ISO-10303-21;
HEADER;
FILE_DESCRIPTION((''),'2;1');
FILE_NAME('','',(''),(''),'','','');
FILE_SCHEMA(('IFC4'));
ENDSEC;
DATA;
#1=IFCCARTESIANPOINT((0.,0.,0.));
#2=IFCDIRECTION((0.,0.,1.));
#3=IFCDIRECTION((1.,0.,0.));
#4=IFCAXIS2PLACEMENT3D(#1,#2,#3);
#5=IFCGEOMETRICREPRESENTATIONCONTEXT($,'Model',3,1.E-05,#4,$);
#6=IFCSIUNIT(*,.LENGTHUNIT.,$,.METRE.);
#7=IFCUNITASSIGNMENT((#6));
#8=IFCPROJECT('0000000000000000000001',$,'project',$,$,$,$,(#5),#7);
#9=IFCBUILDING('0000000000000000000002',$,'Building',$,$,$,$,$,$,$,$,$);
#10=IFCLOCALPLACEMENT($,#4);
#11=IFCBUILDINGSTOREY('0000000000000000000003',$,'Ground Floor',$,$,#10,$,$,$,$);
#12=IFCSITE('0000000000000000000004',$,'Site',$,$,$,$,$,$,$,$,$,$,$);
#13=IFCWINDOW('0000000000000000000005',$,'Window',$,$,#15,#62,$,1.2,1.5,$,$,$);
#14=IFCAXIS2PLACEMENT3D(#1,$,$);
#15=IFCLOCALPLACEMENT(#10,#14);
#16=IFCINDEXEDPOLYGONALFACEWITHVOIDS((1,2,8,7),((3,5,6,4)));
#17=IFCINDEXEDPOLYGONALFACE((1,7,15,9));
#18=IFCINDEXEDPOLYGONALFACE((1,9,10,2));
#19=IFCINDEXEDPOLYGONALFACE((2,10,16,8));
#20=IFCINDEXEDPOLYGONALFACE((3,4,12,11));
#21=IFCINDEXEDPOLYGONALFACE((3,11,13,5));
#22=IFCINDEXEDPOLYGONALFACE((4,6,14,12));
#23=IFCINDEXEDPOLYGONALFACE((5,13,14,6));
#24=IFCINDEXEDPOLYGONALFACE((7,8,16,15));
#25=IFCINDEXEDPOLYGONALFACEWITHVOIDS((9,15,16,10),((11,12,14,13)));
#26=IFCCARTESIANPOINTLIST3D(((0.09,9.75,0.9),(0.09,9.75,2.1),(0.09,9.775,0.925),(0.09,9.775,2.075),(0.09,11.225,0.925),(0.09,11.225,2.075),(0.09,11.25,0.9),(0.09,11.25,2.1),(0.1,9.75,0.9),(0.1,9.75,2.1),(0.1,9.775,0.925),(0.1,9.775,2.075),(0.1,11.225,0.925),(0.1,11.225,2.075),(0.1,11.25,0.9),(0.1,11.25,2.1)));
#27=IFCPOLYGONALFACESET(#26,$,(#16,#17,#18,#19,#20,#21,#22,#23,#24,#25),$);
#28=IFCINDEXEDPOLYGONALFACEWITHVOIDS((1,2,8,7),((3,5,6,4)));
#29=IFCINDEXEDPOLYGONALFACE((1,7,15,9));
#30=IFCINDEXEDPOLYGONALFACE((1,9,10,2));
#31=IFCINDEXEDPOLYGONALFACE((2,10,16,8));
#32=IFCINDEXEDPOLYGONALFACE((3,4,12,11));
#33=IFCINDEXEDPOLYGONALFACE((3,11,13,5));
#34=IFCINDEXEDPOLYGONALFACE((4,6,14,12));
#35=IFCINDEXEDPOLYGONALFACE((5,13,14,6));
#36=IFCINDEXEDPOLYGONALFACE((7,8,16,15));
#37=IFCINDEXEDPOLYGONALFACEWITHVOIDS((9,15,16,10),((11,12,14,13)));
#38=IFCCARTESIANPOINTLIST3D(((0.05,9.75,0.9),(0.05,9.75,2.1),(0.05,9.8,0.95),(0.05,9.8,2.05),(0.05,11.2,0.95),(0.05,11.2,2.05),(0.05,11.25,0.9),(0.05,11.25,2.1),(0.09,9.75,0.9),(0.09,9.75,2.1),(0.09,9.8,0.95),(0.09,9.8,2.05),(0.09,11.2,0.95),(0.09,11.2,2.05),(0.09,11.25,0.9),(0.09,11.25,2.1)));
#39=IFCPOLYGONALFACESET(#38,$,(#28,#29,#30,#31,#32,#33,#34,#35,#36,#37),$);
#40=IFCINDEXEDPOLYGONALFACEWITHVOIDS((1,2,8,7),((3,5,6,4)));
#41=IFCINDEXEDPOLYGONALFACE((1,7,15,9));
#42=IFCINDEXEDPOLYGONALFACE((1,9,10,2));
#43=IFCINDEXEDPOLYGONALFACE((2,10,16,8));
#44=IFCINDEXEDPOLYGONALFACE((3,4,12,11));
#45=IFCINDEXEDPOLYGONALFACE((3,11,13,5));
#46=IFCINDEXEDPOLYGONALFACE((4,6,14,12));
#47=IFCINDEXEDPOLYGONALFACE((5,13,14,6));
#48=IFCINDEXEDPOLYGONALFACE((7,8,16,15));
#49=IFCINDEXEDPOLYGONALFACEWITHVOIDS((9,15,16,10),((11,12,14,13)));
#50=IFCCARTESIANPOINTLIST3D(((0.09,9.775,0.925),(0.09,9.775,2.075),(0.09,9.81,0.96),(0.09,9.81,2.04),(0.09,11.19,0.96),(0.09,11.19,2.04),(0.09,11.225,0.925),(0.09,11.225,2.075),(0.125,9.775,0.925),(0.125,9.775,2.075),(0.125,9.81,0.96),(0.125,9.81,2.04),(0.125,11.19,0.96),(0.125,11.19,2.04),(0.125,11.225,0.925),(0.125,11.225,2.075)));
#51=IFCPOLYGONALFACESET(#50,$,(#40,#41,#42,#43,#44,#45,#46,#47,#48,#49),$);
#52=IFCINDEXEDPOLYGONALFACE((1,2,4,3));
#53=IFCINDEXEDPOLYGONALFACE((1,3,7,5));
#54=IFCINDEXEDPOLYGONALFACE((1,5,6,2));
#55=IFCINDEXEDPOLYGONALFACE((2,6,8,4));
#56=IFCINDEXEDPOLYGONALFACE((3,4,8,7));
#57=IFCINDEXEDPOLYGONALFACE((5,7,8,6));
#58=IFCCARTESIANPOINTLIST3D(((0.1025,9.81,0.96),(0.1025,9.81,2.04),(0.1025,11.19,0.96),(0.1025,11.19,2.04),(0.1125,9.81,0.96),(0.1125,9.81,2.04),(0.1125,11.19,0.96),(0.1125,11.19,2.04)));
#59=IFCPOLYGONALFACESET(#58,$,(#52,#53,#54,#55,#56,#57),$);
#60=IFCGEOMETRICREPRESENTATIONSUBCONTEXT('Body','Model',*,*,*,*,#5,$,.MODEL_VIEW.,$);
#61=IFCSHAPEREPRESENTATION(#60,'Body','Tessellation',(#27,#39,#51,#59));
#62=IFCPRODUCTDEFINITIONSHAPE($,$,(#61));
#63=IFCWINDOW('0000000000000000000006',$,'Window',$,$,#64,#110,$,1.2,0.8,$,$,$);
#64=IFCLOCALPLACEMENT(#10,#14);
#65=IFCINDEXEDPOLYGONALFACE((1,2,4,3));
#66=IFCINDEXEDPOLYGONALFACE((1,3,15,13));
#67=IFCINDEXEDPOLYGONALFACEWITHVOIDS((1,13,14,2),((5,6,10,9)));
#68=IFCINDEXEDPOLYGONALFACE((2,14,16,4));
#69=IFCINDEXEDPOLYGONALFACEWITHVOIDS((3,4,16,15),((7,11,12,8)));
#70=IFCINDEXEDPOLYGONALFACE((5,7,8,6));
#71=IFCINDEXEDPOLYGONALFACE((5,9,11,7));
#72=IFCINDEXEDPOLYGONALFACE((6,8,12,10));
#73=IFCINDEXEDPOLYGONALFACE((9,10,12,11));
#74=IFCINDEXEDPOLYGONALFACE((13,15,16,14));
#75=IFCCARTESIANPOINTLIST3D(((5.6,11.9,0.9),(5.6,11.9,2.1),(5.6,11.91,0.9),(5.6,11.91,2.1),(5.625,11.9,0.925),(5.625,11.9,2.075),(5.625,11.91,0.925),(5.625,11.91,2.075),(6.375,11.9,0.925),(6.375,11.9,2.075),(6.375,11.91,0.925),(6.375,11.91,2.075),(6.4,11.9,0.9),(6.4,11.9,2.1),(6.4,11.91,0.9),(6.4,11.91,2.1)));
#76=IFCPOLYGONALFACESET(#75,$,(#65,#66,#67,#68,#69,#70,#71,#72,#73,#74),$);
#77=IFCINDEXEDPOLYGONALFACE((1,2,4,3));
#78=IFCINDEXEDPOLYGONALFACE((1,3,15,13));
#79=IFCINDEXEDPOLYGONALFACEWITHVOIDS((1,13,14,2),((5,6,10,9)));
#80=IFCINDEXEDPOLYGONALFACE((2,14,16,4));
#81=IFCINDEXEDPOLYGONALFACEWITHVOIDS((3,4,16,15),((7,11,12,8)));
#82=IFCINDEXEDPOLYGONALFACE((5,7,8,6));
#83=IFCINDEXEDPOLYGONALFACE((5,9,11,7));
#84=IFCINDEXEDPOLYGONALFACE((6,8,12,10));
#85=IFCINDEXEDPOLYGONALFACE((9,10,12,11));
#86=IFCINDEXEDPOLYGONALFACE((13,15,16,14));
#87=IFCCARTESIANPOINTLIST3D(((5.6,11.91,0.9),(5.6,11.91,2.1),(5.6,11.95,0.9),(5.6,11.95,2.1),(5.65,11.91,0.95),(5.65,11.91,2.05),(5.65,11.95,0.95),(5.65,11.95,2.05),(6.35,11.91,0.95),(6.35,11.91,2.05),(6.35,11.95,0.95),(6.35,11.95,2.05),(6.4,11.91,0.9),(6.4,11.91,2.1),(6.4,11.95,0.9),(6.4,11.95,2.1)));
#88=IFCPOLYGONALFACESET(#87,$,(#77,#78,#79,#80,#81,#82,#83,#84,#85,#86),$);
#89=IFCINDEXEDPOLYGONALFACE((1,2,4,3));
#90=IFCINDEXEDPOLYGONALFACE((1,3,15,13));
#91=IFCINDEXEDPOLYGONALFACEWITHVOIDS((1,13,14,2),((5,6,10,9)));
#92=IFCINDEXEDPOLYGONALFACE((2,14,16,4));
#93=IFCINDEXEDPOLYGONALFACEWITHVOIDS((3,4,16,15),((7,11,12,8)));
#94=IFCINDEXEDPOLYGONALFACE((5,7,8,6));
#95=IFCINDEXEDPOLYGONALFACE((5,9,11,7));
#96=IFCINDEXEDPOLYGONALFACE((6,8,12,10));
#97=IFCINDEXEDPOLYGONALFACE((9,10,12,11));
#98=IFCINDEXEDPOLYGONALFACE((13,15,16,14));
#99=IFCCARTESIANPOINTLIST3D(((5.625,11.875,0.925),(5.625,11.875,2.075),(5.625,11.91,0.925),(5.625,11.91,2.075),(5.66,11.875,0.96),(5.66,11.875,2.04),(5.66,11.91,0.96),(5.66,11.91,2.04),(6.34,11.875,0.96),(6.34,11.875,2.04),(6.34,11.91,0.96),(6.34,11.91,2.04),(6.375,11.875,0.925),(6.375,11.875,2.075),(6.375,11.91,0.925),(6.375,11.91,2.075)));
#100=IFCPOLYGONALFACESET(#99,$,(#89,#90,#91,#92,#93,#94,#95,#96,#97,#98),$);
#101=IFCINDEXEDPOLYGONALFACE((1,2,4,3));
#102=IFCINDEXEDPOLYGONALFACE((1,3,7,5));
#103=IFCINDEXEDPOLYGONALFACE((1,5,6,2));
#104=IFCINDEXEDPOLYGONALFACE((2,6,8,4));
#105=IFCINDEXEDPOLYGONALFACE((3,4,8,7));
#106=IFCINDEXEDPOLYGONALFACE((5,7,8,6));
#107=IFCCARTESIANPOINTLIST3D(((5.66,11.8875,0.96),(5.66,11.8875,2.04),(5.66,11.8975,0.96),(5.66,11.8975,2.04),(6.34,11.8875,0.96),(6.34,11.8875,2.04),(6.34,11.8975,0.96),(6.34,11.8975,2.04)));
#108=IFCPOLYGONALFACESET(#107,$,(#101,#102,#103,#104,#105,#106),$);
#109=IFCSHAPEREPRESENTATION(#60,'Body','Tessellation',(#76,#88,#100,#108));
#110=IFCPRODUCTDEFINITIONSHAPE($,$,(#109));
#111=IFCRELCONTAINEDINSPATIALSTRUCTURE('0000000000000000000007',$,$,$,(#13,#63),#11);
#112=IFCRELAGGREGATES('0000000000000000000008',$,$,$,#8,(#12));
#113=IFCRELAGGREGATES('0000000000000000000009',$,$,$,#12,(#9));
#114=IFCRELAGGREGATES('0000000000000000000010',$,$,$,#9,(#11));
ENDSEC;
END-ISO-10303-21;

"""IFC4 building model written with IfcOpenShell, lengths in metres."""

from ifc_helpers import new_model, si_unit, frame, origin_with_axes, place, context, subcontext, project, spatial, line, indexed_curve, outline, extrude, element, save


model = new_model("IFC4")

# Units and contexts
model_context = context("Model", 3, precision=1e-05, world=origin_with_axes())
body_context = subcontext(model_context, "Body", "Model", "MODEL_VIEW")
ifc_project = project(units=[si_unit("LENGTHUNIT", "METRE")], contexts=[model_context])

# Site, building, storey
site = spatial("IfcSite", under=ifc_project, Name="Site")
building = spatial("IfcBuilding", under=site, Name="Building")
storey_placement = place(None, origin_with_axes())
storey = spatial("IfcBuildingStorey", under=building, at=storey_placement, Name="Ground Floor")

# Windows
window_1_placement = place(storey_placement, frame((0.0, 11.25, 0.9), z_axis=(0.0, 0.0, 1.0), x_axis=(0.0, -1.0, 0.0)))
element("IfcWindow", 1, at=window_1_placement, inside=storey, Name="Window", OverallHeight=1.2, OverallWidth=1.5, context=body_context, shape_type="SweptSolid", body=[
    extrude(outline(indexed_curve([(0.0, 0.0), (1.5, 0.0), (1.5, 1.2), (0.0, 1.2)], segments=[line(1, 2, 3, 4, 1)]), holes=[indexed_curve([(0.025, 0.025), (1.475, 0.025), (1.475, 1.175), (0.025, 1.175)], segments=[line(1, 2, 3, 4, 1)])]), frame((0.0, 0.09, 0.0), z_axis=(0.0, -1.0, 0.0), x_axis=(1.0, 0.0, 0.0)), (0.0, 0.0, -1.0), 0.01),
    extrude(outline(indexed_curve([(0.0, 0.0), (1.5, 0.0), (1.5, 1.2), (0.0, 1.2)], segments=[line(1, 2, 3, 4, 1)]), holes=[indexed_curve([(0.05, 0.05), (1.45, 0.05), (1.45, 1.15), (0.05, 1.15)], segments=[line(1, 2, 3, 4, 1)])]), frame((0.0, 0.05, 0.0), z_axis=(0.0, -1.0, 0.0), x_axis=(1.0, 0.0, 0.0)), (0.0, 0.0, -1.0), 0.04),
    extrude(outline(indexed_curve([(0.0, 0.0), (1.45, 0.0), (1.45, 1.15), (0.0, 1.15)], segments=[line(1, 2, 3, 4, 1)]), holes=[indexed_curve([(0.035, 0.035), (1.415, 0.035), (1.415, 1.115), (0.035, 1.115)], segments=[line(1, 2, 3, 4, 1)])]), frame((0.025, 0.09, 0.025), z_axis=(0.0, -1.0, 0.0), x_axis=(1.0, 0.0, 0.0)), (0.0, 0.0, -1.0), 0.035),
    extrude(outline(indexed_curve([(0.035, 0.035), (1.415, 0.035), (1.415, 1.115), (0.035, 1.115)], segments=[line(1, 2, 3, 4, 1)])), frame((0.025, 0.1025, 0.025), z_axis=(0.0, -1.0, 0.0), x_axis=(1.0, 0.0, 0.0)), (0.0, 0.0, -1.0), 0.01),
])
window_2_placement = place(storey_placement, frame((6.4, 12.0, 0.9), z_axis=(0.0, 0.0, 1.0), x_axis=(-1.0, 0.0, 0.0)))
element("IfcWindow", 2, at=window_2_placement, inside=storey, Name="Window", OverallHeight=1.2, OverallWidth=0.8, context=body_context, shape_type="SweptSolid", body=[
    extrude(outline(indexed_curve([(0.0, 0.0), (0.8, 0.0), (0.8, 1.2), (0.0, 1.2)], segments=[line(1, 2, 3, 4, 1)]), holes=[indexed_curve([(0.025, 0.025), (0.775, 0.025), (0.775, 1.175), (0.025, 1.175)], segments=[line(1, 2, 3, 4, 1)])]), frame((0.0, 0.09, 0.0), z_axis=(0.0, -1.0, 0.0), x_axis=(1.0, 0.0, 0.0)), (0.0, 0.0, -1.0), 0.01),
    extrude(outline(indexed_curve([(0.0, 0.0), (0.8, 0.0), (0.8, 1.2), (0.0, 1.2)], segments=[line(1, 2, 3, 4, 1)]), holes=[indexed_curve([(0.05, 0.05), (0.75, 0.05), (0.75, 1.15), (0.05, 1.15)], segments=[line(1, 2, 3, 4, 1)])]), frame((0.0, 0.05, 0.0), z_axis=(0.0, -1.0, 0.0), x_axis=(1.0, 0.0, 0.0)), (0.0, 0.0, -1.0), 0.04),
    extrude(outline(indexed_curve([(0.0, 0.0), (0.75, 0.0), (0.75, 1.15), (0.0, 1.15)], segments=[line(1, 2, 3, 4, 1)]), holes=[indexed_curve([(0.035, 0.035), (0.715, 0.035), (0.715, 1.115), (0.035, 1.115)], segments=[line(1, 2, 3, 4, 1)])]), frame((0.025, 0.09, 0.025), z_axis=(0.0, -1.0, 0.0), x_axis=(1.0, 0.0, 0.0)), (0.0, 0.0, -1.0), 0.035),
    extrude(outline(indexed_curve([(0.035, 0.035), (0.715, 0.035), (0.715, 1.115), (0.035, 1.115)], segments=[line(1, 2, 3, 4, 1)])), frame((0.025, 0.1025, 0.025), z_axis=(0.0, -1.0, 0.0), x_axis=(1.0, 0.0, 0.0)), (0.0, 0.0, -1.0), 0.01),
])

save(model, "model.ifc")
